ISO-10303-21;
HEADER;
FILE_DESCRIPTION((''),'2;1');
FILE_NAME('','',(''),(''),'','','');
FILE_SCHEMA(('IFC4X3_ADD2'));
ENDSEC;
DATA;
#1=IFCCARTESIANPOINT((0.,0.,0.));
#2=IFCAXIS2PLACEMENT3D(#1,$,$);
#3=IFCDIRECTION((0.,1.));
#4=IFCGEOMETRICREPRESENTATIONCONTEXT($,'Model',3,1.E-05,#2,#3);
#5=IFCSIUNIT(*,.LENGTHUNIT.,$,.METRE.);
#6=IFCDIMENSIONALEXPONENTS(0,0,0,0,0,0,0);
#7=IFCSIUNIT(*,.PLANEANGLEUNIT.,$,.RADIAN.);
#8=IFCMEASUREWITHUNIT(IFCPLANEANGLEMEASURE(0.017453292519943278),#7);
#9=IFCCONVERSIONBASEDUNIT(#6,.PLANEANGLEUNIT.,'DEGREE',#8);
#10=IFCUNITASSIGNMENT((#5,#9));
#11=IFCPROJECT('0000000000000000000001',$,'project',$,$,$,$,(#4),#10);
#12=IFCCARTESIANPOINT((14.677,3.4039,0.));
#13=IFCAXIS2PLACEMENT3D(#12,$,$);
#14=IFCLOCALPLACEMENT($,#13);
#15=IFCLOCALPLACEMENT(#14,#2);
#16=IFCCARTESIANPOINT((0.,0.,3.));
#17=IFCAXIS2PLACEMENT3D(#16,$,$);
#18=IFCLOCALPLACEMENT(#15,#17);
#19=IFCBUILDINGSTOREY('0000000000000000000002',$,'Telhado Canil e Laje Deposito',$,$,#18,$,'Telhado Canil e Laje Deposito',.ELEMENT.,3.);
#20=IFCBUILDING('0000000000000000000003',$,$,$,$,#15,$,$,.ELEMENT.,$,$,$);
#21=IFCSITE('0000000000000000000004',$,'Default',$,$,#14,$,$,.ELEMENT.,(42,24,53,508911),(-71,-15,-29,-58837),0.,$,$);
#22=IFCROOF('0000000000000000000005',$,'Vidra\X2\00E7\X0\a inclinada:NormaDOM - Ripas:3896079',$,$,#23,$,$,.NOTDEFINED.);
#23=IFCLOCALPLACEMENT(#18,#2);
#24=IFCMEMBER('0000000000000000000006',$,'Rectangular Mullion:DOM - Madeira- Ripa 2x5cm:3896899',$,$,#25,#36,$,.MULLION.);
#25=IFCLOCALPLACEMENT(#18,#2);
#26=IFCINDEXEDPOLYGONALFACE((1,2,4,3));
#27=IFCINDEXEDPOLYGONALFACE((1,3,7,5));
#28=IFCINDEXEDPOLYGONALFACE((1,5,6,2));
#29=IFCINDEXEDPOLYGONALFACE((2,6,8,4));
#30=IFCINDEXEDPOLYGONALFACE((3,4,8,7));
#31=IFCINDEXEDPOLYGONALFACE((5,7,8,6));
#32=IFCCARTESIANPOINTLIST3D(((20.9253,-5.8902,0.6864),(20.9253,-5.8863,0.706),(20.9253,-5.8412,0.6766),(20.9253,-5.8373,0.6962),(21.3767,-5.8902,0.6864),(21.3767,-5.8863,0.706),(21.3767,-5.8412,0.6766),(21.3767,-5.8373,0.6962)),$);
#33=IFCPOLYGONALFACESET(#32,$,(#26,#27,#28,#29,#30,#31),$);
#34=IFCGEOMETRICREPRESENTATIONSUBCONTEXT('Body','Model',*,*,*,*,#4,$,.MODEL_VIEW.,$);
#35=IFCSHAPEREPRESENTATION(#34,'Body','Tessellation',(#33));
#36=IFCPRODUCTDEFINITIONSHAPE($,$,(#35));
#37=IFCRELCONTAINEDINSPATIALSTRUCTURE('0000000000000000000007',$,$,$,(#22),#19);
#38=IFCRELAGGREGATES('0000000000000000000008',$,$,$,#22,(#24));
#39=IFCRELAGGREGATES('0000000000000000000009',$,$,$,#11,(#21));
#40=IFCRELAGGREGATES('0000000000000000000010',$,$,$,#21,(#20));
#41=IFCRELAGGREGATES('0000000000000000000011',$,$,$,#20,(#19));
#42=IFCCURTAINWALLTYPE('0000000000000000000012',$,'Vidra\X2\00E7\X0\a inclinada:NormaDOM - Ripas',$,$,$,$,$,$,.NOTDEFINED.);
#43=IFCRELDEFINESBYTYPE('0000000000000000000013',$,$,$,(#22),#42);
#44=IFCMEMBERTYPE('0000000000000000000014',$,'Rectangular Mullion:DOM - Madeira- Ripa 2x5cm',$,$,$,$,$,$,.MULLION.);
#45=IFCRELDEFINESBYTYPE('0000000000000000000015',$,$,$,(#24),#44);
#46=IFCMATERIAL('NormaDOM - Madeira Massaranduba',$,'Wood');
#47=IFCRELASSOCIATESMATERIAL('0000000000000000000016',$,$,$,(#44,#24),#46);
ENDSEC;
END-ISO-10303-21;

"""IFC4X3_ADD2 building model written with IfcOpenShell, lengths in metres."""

from ifc_helpers import new_model, entity, si_unit, converted_unit, direction, frame, origin, origin_2d_with_axis, place, context, subcontext, project, spatial, rectangle, extrude, source, transform, mapped, material, material_profile, profile_set, profile_usage, type_object, type_shapes, element, aggregate, save


model = new_model("IFC4X3_ADD2")

# Units and contexts
model_context = context("Model", 3, precision=1e-05, world=origin(), true_north=direction((0.0, 1.0)))
body_context = subcontext(model_context, "Body", "Model", "MODEL_VIEW")
ifc_project = project(units=[si_unit("LENGTHUNIT", "METRE"), converted_unit("PLANEANGLEUNIT", "DEGREE", entity("IfcPlaneAngleMeasure", 0.017453292519943278), si_unit("PLANEANGLEUNIT", "RADIAN"), dimensions=[0, 0, 0, 0, 0, 0, 0])], contexts=[model_context])

# Site, building, storey
site_placement = place(None, frame((14.677, 3.4039, 0.0)))
site = spatial("IfcSite", under=ifc_project, at=site_placement, Name="Default", CompositionType="ELEMENT", RefLatitude=(42, 24, 53, 508911), RefLongitude=(-71, -15, -29, -58837), RefElevation=0.0)
building_placement = place(site_placement, origin())
building = spatial("IfcBuilding", under=site, at=building_placement, CompositionType="ELEMENT")
storey_placement = place(building_placement, frame((0.0, 0.0, 3.0)))
storey = spatial("IfcBuildingStorey", under=building, at=storey_placement, Name="Telhado Canil e Laje Deposito", LongName="Telhado Canil e Laje Deposito", CompositionType="ELEMENT", Elevation=3.0)

# Roof
ifc_material = material(Name="NormaDOM - Madeira Massaranduba", Category="Wood")
ifc_material_profile_1 = material_profile(ifc_material, rectangle(XDim=0.05, YDim=0.02, at=origin_2d_with_axis()), Name="DOM - Madeira- Ripa 2x5cm")
ifc_profile_set_1 = profile_set([ifc_material_profile_1], Name="DOM - Madeira- Ripa 2x5cm")
ifc_profile_usage_1 = profile_usage(ifc_profile_set_1)
curtain_wall_type_1 = type_object("IfcCurtainWallType", Name="Vidraça inclinada:NormaDOM - Ripas", PredefinedType="NOTDEFINED")
roof_1_placement = place(storey_placement, frame((0.0, 0.0, -3.0)))
roof_1 = element("IfcRoof", 1, at=roof_1_placement, inside=storey, type_object=curtain_wall_type_1, Name="Vidraça inclinada:NormaDOM - Ripas:3896079", PredefinedType="NOTDEFINED")

# Member
member_type_1 = type_object("IfcMemberType", Name="Rectangular Mullion:DOM - Madeira- Ripa 2x5cm", PredefinedType="MULLION", material=ifc_profile_set_1)
shared_shape_1 = source(origin(), body_context, "Body", "SweptSolid", [
    extrude(rectangle(XDim=0.05, YDim=0.02, at=origin_2d_with_axis()), frame((0.025, 0.01, -0.4514), z_axis=(0.0, 0.0, 1.0), x_axis=(-1.0, 0.0, 0.0)), (0.0, 0.0, 1.0), 0.4514),
])
type_shapes(member_type_1, [shared_shape_1])
member_1_placement = place(roof_1_placement, frame((21.3767, -5.8373, 3.6962), z_axis=(1.0, 0.0, 0.0), x_axis=(0.0, -0.980581, 0.196116)))
member_1 = element("IfcMember", 2, at=member_1_placement, type_object=member_type_1, material=ifc_profile_usage_1, Name="Rectangular Mullion:DOM - Madeira- Ripa 2x5cm:3896899", PredefinedType="MULLION", context=body_context, shape_type="MappedRepresentation", body=[
    mapped(shared_shape_1, transform((0.0, 0.0, 0.0), scale=1.0)),
])
aggregate(roof_1, [member_1])

save(model, "model.ifc")
